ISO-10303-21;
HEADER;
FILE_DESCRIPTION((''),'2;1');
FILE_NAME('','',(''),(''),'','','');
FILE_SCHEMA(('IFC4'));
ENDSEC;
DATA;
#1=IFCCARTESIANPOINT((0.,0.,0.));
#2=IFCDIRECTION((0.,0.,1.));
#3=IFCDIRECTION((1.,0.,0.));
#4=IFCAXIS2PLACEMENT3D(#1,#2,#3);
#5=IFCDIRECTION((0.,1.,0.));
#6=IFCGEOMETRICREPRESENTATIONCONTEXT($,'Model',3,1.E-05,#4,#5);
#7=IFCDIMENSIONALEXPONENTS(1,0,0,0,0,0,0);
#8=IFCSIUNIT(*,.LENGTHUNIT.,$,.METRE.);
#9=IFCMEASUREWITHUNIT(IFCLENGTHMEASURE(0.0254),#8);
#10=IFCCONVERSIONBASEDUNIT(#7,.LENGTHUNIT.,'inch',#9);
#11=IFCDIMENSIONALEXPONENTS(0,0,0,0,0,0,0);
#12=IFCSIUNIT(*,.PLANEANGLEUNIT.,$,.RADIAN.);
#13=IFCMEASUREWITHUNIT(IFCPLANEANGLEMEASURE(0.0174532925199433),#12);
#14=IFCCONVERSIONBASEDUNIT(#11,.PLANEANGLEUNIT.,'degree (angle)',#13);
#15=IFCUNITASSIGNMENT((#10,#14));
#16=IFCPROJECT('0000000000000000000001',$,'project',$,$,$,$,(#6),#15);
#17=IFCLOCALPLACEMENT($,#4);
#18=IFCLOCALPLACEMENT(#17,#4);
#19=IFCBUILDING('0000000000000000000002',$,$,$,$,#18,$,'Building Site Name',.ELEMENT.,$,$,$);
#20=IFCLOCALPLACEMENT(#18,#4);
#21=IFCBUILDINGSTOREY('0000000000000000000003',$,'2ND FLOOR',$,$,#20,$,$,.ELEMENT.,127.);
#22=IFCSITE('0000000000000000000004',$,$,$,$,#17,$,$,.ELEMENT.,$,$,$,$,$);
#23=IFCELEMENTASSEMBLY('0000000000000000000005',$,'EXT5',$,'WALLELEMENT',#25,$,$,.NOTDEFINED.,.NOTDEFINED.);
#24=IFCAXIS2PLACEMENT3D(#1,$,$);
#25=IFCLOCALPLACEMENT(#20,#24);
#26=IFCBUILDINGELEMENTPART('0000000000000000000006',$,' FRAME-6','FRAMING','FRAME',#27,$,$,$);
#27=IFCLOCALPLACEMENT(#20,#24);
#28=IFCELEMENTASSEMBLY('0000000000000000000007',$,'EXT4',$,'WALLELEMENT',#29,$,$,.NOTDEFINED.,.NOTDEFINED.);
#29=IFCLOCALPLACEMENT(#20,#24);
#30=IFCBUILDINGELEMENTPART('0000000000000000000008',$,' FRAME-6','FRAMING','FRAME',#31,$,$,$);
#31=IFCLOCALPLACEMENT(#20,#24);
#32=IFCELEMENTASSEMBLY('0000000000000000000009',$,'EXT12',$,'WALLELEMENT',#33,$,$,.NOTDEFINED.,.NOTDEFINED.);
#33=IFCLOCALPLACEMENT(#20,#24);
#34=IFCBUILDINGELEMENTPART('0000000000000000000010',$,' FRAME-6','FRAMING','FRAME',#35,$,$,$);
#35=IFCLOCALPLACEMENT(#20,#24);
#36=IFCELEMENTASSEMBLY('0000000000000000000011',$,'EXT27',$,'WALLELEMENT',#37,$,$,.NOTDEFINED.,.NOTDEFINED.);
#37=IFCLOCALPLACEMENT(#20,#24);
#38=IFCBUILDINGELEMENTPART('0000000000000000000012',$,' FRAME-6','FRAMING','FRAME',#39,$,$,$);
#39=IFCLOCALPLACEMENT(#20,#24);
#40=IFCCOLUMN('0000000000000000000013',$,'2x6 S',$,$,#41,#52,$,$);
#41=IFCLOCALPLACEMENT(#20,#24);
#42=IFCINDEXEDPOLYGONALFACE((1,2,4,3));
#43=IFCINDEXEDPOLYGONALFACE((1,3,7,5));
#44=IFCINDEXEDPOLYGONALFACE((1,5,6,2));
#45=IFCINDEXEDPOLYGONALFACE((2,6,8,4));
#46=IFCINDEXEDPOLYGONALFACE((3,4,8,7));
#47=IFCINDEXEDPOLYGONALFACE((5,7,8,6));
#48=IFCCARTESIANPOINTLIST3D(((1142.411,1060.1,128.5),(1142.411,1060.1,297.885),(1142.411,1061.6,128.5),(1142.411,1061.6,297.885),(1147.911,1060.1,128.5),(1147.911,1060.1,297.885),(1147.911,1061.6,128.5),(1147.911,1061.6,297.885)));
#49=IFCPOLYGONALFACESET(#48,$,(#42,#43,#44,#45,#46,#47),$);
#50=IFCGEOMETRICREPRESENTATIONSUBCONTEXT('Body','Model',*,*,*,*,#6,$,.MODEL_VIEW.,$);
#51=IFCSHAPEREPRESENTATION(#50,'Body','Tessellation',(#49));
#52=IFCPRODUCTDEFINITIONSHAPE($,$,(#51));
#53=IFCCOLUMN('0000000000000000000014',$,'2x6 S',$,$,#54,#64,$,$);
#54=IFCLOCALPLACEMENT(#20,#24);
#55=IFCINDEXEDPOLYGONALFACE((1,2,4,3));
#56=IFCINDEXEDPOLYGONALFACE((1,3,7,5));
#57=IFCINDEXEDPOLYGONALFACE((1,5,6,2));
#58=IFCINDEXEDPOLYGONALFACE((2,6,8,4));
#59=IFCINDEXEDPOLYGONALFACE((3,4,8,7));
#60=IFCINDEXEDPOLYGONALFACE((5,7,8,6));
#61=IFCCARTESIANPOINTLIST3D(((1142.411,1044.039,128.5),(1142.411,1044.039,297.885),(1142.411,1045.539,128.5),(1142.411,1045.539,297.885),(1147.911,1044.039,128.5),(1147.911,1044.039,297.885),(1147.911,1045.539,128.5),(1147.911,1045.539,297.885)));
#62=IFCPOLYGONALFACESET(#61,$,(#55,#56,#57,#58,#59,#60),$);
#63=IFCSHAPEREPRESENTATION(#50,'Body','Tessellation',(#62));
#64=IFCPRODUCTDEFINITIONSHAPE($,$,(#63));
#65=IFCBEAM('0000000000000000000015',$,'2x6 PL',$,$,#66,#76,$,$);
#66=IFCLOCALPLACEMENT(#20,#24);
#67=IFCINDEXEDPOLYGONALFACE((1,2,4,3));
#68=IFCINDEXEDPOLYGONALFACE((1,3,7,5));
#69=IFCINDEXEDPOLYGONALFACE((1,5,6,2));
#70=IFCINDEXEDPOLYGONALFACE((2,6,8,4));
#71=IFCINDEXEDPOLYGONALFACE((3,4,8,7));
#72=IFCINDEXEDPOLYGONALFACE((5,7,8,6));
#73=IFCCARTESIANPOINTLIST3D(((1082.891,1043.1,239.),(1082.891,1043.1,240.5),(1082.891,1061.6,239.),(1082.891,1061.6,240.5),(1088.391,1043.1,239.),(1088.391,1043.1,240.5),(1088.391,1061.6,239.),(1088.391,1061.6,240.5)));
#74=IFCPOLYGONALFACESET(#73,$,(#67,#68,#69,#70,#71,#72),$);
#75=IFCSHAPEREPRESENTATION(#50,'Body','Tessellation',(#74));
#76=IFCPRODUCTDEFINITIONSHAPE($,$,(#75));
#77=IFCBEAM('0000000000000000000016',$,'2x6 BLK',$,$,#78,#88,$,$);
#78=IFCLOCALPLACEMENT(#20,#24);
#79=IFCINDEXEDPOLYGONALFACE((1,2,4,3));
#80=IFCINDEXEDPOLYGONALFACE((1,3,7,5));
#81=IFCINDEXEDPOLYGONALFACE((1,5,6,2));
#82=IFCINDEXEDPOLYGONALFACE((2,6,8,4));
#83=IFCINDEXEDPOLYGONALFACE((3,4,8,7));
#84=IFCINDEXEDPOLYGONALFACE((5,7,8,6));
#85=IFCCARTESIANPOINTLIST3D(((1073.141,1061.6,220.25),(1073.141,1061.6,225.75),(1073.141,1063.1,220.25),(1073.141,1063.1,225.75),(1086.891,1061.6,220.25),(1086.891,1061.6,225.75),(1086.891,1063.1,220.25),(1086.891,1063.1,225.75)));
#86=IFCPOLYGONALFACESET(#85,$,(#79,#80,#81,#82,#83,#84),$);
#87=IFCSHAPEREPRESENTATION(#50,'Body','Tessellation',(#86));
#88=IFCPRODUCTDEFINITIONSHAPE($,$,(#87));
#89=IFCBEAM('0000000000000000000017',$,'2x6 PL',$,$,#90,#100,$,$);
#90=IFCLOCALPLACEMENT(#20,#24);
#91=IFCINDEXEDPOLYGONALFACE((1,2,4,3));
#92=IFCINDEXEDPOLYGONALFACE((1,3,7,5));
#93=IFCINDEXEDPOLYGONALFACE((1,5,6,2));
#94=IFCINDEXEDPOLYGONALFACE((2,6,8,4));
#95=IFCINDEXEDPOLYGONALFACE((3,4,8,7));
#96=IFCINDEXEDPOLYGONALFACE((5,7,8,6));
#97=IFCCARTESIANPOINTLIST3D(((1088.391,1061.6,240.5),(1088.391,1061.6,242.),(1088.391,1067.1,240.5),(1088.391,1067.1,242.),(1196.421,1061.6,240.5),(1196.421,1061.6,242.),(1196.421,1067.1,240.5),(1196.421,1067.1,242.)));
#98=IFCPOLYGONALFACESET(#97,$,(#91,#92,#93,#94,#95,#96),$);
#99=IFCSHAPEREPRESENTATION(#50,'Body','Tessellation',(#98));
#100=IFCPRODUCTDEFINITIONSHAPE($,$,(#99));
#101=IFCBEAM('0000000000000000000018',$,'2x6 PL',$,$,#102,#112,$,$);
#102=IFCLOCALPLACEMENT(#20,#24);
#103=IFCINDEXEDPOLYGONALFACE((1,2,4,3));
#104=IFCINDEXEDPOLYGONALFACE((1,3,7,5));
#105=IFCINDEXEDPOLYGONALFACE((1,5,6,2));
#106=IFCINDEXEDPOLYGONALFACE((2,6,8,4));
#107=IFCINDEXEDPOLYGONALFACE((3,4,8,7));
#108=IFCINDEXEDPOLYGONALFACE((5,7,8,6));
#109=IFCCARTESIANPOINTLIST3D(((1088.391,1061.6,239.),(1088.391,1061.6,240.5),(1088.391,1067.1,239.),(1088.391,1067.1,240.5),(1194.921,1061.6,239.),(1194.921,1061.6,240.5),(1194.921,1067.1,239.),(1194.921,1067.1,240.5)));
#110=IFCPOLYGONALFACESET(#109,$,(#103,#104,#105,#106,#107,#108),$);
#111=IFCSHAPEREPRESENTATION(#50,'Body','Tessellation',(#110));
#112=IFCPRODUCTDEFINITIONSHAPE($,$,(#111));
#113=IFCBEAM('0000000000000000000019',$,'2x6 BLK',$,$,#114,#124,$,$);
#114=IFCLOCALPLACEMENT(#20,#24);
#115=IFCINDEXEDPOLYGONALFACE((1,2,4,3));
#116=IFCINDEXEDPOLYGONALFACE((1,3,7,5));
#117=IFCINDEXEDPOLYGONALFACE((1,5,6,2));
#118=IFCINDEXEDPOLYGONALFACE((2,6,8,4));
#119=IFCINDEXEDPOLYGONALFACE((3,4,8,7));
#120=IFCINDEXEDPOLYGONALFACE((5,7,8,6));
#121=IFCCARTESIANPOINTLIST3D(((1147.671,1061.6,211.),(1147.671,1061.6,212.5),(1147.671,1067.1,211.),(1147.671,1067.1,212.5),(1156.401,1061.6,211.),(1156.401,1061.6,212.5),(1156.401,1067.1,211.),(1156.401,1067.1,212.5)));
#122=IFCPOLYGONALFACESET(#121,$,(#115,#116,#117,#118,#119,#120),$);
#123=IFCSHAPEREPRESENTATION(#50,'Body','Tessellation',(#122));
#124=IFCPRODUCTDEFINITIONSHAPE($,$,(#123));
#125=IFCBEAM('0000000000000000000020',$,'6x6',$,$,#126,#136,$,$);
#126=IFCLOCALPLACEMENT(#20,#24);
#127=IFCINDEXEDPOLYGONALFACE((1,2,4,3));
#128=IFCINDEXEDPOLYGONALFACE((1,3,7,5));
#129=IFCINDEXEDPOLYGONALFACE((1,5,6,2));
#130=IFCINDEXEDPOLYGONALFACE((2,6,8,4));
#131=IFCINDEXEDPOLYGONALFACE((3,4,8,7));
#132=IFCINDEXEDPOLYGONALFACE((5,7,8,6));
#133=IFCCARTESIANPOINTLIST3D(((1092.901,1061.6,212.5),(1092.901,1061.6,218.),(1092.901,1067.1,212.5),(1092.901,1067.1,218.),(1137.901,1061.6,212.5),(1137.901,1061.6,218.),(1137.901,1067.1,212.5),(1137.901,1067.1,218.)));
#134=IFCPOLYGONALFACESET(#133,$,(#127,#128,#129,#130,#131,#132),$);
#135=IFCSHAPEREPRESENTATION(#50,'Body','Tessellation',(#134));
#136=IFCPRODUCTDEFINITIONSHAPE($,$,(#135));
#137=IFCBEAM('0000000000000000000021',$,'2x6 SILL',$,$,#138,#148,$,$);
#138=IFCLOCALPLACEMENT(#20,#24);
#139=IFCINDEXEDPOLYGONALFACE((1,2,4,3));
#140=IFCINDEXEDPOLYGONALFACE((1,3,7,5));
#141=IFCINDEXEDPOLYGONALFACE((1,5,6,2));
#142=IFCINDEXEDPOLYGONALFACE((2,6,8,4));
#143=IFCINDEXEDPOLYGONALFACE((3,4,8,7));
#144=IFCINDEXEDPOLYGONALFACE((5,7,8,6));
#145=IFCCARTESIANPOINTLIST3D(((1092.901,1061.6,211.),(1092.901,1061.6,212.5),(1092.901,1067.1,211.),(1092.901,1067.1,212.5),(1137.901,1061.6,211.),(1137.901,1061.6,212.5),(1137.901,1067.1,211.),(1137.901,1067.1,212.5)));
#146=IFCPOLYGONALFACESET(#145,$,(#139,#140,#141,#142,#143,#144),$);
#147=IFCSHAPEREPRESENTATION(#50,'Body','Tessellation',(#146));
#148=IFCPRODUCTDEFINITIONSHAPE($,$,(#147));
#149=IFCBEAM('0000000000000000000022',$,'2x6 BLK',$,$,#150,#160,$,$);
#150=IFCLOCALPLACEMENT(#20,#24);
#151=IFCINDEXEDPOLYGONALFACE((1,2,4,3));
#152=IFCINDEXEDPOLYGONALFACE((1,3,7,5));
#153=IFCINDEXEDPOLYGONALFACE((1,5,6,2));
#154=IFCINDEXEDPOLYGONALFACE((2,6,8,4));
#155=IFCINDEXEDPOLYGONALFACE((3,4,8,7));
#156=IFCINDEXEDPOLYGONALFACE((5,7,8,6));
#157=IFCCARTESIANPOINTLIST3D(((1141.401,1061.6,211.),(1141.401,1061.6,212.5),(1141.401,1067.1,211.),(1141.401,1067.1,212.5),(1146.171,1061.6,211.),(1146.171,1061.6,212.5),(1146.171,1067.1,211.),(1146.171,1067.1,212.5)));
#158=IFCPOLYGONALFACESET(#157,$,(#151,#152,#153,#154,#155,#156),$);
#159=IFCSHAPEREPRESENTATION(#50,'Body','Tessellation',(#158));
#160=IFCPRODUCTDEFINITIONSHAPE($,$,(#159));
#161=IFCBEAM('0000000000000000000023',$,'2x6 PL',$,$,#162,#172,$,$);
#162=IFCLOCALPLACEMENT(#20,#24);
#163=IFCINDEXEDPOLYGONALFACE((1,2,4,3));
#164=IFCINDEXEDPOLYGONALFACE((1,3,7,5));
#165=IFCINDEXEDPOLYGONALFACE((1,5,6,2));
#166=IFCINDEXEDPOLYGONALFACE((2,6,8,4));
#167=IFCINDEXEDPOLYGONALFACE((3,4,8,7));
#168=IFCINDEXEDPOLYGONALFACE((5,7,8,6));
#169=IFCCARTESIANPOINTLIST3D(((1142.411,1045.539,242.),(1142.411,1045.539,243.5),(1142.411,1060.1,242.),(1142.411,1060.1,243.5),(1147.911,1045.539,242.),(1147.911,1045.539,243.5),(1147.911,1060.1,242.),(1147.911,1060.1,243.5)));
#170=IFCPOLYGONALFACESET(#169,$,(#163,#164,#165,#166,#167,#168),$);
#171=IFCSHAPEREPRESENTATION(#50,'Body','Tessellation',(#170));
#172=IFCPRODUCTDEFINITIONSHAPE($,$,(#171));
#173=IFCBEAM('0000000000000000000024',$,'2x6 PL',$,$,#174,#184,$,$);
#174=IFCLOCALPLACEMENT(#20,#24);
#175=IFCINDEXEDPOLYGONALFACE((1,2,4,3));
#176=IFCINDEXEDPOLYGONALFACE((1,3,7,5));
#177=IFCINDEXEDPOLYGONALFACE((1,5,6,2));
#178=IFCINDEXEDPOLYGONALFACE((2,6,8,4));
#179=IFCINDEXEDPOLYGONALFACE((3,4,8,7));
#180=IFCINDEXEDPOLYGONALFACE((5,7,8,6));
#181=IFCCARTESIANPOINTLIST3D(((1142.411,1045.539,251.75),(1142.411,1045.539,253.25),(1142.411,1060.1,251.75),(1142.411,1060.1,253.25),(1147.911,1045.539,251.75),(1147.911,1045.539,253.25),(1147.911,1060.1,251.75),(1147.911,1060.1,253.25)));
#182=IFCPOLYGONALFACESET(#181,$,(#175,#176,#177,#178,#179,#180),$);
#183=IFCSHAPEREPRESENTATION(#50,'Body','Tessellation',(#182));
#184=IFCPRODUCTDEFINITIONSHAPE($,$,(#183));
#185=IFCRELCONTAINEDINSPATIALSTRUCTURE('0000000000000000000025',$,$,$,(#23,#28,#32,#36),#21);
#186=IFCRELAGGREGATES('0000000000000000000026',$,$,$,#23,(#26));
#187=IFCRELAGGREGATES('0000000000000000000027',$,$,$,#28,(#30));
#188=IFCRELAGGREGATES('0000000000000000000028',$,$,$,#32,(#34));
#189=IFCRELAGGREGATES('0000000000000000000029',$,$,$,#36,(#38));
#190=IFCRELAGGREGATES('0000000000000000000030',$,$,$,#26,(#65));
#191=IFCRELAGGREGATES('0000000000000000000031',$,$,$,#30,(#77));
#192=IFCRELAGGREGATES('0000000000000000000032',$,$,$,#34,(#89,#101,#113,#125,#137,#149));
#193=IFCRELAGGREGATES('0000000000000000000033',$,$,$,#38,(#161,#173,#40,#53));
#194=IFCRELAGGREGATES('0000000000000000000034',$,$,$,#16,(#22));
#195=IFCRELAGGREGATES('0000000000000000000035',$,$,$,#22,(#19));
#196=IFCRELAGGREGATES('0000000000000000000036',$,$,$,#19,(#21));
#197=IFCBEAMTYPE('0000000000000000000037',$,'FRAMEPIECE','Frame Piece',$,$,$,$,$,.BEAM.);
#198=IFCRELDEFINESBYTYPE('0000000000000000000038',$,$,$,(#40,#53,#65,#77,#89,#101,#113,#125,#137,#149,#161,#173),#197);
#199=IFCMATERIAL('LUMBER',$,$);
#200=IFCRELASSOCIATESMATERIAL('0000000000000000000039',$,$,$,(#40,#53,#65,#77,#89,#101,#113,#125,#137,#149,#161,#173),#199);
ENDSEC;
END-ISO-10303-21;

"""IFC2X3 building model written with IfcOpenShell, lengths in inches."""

from ifc_helpers import new_model, entity, si_unit, converted_unit, direction, frame, frame_2d, origin_with_axes, place, context, subcontext, project, spatial, rectangle, extrude, material, type_object, element, aggregate, save


model = new_model("IFC2X3")

# Units and contexts
model_context = context("Model", 3, precision=1e-05, world=origin_with_axes(), true_north=direction((0.0, 1.0, 0.0)))
body_context = subcontext(model_context, "Body", "Model", "MODEL_VIEW")
ifc_project = project(units=[converted_unit("LENGTHUNIT", "inch", entity("IfcLengthMeasure", 0.0254), si_unit("LENGTHUNIT", "METRE"), dimensions=[1, 0, 0, 0, 0, 0, 0]), converted_unit("PLANEANGLEUNIT", "degree (angle)", entity("IfcPlaneAngleMeasure", 0.0174532925199433), si_unit("PLANEANGLEUNIT", "RADIAN"), dimensions=[0, 0, 0, 0, 0, 0, 0])], contexts=[model_context])

# Site, building, storey
site_placement = place(None, origin_with_axes())
site = spatial("IfcSite", under=ifc_project, at=site_placement, CompositionType="ELEMENT")
building_placement = place(site_placement, origin_with_axes())
building = spatial("IfcBuilding", under=site, at=building_placement, LongName="Building Site Name", CompositionType="ELEMENT")
storey_placement = place(building_placement, origin_with_axes())
storey = spatial("IfcBuildingStorey", under=building, at=storey_placement, Name="2ND FLOOR", CompositionType="ELEMENT", Elevation=127.0)

# Element assemblies, building element parts, columns
assembly_1_placement = place(storey_placement, origin_with_axes())
assembly_1 = element("IfcElementAssembly", 1, at=assembly_1_placement, inside=storey, Name="EXT5", ObjectType="WALLELEMENT", AssemblyPlace="NOTDEFINED", PredefinedType="NOTDEFINED")
building_element_part_1 = element("IfcBuildingElementPart", 2, Name=" FRAME-6", Description="FRAMING", ObjectType="FRAME")
aggregate(assembly_1, [building_element_part_1])
ifc_material = material(Name="LUMBER")
beam_type = type_object("IfcBeamType", Name="FRAMEPIECE", Description="Frame Piece", PredefinedType="BEAM")
assembly_2_placement = place(storey_placement, origin_with_axes())
assembly_2 = element("IfcElementAssembly", 3, at=assembly_2_placement, inside=storey, Name="EXT4", ObjectType="WALLELEMENT", AssemblyPlace="NOTDEFINED", PredefinedType="NOTDEFINED")
building_element_part_2 = element("IfcBuildingElementPart", 4, Name=" FRAME-6", Description="FRAMING", ObjectType="FRAME")
aggregate(assembly_2, [building_element_part_2])
assembly_3_placement = place(storey_placement, origin_with_axes())
assembly_3 = element("IfcElementAssembly", 5, at=assembly_3_placement, inside=storey, Name="EXT12", ObjectType="WALLELEMENT", AssemblyPlace="NOTDEFINED", PredefinedType="NOTDEFINED")
building_element_part_3 = element("IfcBuildingElementPart", 6, Name=" FRAME-6", Description="FRAMING", ObjectType="FRAME")
aggregate(assembly_3, [building_element_part_3])
assembly_4_placement = place(storey_placement, origin_with_axes())
assembly_4 = element("IfcElementAssembly", 7, at=assembly_4_placement, inside=storey, Name="EXT27", ObjectType="WALLELEMENT", AssemblyPlace="NOTDEFINED", PredefinedType="NOTDEFINED")
building_element_part_4 = element("IfcBuildingElementPart", 8, Name=" FRAME-6", Description="FRAMING", ObjectType="FRAME")
aggregate(assembly_4, [building_element_part_4])
column_1_placement = place(assembly_4_placement, frame((1145.161, 1060.85, 297.885), z_axis=(0.0, 0.0, -1.0), x_axis=(0.0, -1.0, 0.0)))
column_1 = element("IfcColumn", 9, at=column_1_placement, type_object=beam_type, material=ifc_material, Name="2x6 S", context=body_context, shape_type="SweptSolid", body=[
    extrude(rectangle(XDim=1.5, YDim=5.5, at=frame_2d((0.0, 0.0), x_axis=(-1.0, 0.0))), origin_with_axes(), (0.0, 0.0, 1.0), 169.385),
])
column_2_placement = place(assembly_4_placement, frame((1145.161, 1044.789, 297.885), z_axis=(0.0, 0.0, -1.0), x_axis=(0.0, -1.0, 0.0)))
column_2 = element("IfcColumn", 10, at=column_2_placement, type_object=beam_type, material=ifc_material, Name="2x6 S", context=body_context, shape_type="SweptSolid", body=[
    extrude(rectangle(XDim=1.5, YDim=5.5, at=frame_2d((0.0, 0.0), x_axis=(-1.0, 0.0))), origin_with_axes(), (0.0, 0.0, 1.0), 169.385),
])

# Beams
beam_1_placement = place(assembly_1_placement, frame((1085.641, 1043.1, 239.75), z_axis=(0.0, 1.0, 0.0), x_axis=(0.0, 0.0, -1.0)))
beam_1 = element("IfcBeam", 11, at=beam_1_placement, type_object=beam_type, material=ifc_material, Name="2x6 PL", context=body_context, shape_type="SweptSolid", body=[
    extrude(rectangle(XDim=1.5, YDim=5.5, at=frame_2d((0.0, 0.0), x_axis=(-1.0, 0.0))), origin_with_axes(), (0.0, 0.0, 1.0), 18.5),
])
aggregate(building_element_part_1, [beam_1])
beam_2_placement = place(assembly_2_placement, frame((1073.141, 1062.35, 223.0), z_axis=(1.0, 0.0, 0.0), x_axis=(0.0, -1.0, 0.0)))
beam_2 = element("IfcBeam", 12, at=beam_2_placement, type_object=beam_type, material=ifc_material, Name="2x6 BLK", context=body_context, shape_type="SweptSolid", body=[
    extrude(rectangle(XDim=1.5, YDim=5.5, at=frame_2d((0.0, 0.0), x_axis=(-1.0, 0.0))), origin_with_axes(), (0.0, 0.0, 1.0), 13.75),
])
aggregate(building_element_part_2, [beam_2])
beam_3_placement = place(assembly_3_placement, frame((1088.391, 1064.35, 241.25), z_axis=(1.0, 0.0, 0.0), x_axis=(0.0, 0.0, -1.0)))
beam_3 = element("IfcBeam", 13, at=beam_3_placement, type_object=beam_type, material=ifc_material, Name="2x6 PL", context=body_context, shape_type="SweptSolid", body=[
    extrude(rectangle(XDim=1.5, YDim=5.5, at=frame_2d((0.0, 0.0), x_axis=(-1.0, 0.0))), origin_with_axes(), (0.0, 0.0, 1.0), 108.03),
])
beam_4_placement = place(assembly_3_placement, frame((1088.391, 1064.35, 239.75), z_axis=(1.0, 0.0, 0.0), x_axis=(0.0, 0.0, -1.0)))
beam_4 = element("IfcBeam", 14, at=beam_4_placement, type_object=beam_type, material=ifc_material, Name="2x6 PL", context=body_context, shape_type="SweptSolid", body=[
    extrude(rectangle(XDim=1.5, YDim=5.5, at=frame_2d((0.0, 0.0), x_axis=(-1.0, 0.0))), frame((0.0, 0.0, 0.0), z_axis=(0.0, 0.0, 1.0), x_axis=(1.0, 0.0, 0.0)), (0.0, 0.0, 1.0), 106.53),
])
beam_5_placement = place(assembly_3_placement, frame((1147.671, 1064.35, 211.75), z_axis=(1.0, 0.0, 0.0), x_axis=(0.0, 0.0, -1.0)))
beam_5 = element("IfcBeam", 15, at=beam_5_placement, type_object=beam_type, material=ifc_material, Name="2x6 BLK", context=body_context, shape_type="SweptSolid", body=[
    extrude(rectangle(XDim=1.5, YDim=5.5, at=frame_2d((0.0, 0.0), x_axis=(-1.0, 0.0))), origin_with_axes(), (0.0, 0.0, 1.0), 8.73),
])
beam_6_placement = place(assembly_3_placement, frame((1137.901, 1064.35, 215.25), z_axis=(-1.0, 0.0, 0.0), x_axis=(0.0, -1.0, 0.0)))
beam_6 = element("IfcBeam", 16, at=beam_6_placement, type_object=beam_type, material=ifc_material, Name="6x6", context=body_context, shape_type="SweptSolid", body=[
    extrude(rectangle(XDim=5.5, YDim=5.5, at=frame_2d((0.0, 0.0), x_axis=(-1.0, 0.0))), frame((0.0, 0.0, 0.0), z_axis=(0.0, 0.0, 1.0), x_axis=(1.0, 0.0, 0.0)), (0.0, 0.0, 1.0), 45.0),
])
beam_7_placement = place(assembly_3_placement, frame((1137.901, 1064.35, 211.75), z_axis=(-1.0, 0.0, 0.0), x_axis=(0.0, 0.0, 1.0)))
beam_7 = element("IfcBeam", 17, at=beam_7_placement, type_object=beam_type, material=ifc_material, Name="2x6 SILL", context=body_context, shape_type="SweptSolid", body=[
    extrude(rectangle(XDim=1.5, YDim=5.5, at=frame_2d((0.0, 0.0), x_axis=(-1.0, 0.0))), frame((0.0, 0.0, 0.0), z_axis=(0.0, 0.0, 1.0), x_axis=(1.0, 0.0, 0.0)), (0.0, 0.0, 1.0), 45.0),
])
beam_8_placement = place(assembly_3_placement, frame((1141.401, 1064.35, 211.75), z_axis=(1.0, 0.0, 0.0), x_axis=(0.0, 0.0, -1.0)))
beam_8 = element("IfcBeam", 18, at=beam_8_placement, type_object=beam_type, material=ifc_material, Name="2x6 BLK", context=body_context, shape_type="SweptSolid", body=[
    extrude(rectangle(XDim=1.5, YDim=5.5, at=frame_2d((0.0, 0.0), x_axis=(-1.0, 0.0))), origin_with_axes(), (0.0, 0.0, 1.0), 4.77),
])
aggregate(building_element_part_3, [beam_3, beam_4, beam_5, beam_6, beam_7, beam_8])
beam_9_placement = place(assembly_4_placement, frame((1145.161, 1045.539, 242.75), z_axis=(0.0, 1.0, 0.0), x_axis=(0.0, 0.0, -1.0)))
beam_9 = element("IfcBeam", 19, at=beam_9_placement, type_object=beam_type, material=ifc_material, Name="2x6 PL", context=body_context, shape_type="SweptSolid", body=[
    extrude(rectangle(XDim=1.5, YDim=5.5, at=frame_2d((0.0, 0.0), x_axis=(-1.0, 0.0))), origin_with_axes(), (0.0, 0.0, 1.0), 14.56),
])
beam_10_placement = place(assembly_4_placement, frame((1145.161, 1045.539, 252.5), z_axis=(0.0, 1.0, 0.0), x_axis=(0.0, 0.0, -1.0)))
beam_10 = element("IfcBeam", 20, at=beam_10_placement, type_object=beam_type, material=ifc_material, Name="2x6 PL", context=body_context, shape_type="SweptSolid", body=[
    extrude(rectangle(XDim=1.5, YDim=5.5, at=frame_2d((0.0, 0.0), x_axis=(-1.0, 0.0))), origin_with_axes(), (0.0, 0.0, 1.0), 14.56),
])
aggregate(building_element_part_4, [beam_9, beam_10, column_1, column_2])

save(model, "model.ifc")
